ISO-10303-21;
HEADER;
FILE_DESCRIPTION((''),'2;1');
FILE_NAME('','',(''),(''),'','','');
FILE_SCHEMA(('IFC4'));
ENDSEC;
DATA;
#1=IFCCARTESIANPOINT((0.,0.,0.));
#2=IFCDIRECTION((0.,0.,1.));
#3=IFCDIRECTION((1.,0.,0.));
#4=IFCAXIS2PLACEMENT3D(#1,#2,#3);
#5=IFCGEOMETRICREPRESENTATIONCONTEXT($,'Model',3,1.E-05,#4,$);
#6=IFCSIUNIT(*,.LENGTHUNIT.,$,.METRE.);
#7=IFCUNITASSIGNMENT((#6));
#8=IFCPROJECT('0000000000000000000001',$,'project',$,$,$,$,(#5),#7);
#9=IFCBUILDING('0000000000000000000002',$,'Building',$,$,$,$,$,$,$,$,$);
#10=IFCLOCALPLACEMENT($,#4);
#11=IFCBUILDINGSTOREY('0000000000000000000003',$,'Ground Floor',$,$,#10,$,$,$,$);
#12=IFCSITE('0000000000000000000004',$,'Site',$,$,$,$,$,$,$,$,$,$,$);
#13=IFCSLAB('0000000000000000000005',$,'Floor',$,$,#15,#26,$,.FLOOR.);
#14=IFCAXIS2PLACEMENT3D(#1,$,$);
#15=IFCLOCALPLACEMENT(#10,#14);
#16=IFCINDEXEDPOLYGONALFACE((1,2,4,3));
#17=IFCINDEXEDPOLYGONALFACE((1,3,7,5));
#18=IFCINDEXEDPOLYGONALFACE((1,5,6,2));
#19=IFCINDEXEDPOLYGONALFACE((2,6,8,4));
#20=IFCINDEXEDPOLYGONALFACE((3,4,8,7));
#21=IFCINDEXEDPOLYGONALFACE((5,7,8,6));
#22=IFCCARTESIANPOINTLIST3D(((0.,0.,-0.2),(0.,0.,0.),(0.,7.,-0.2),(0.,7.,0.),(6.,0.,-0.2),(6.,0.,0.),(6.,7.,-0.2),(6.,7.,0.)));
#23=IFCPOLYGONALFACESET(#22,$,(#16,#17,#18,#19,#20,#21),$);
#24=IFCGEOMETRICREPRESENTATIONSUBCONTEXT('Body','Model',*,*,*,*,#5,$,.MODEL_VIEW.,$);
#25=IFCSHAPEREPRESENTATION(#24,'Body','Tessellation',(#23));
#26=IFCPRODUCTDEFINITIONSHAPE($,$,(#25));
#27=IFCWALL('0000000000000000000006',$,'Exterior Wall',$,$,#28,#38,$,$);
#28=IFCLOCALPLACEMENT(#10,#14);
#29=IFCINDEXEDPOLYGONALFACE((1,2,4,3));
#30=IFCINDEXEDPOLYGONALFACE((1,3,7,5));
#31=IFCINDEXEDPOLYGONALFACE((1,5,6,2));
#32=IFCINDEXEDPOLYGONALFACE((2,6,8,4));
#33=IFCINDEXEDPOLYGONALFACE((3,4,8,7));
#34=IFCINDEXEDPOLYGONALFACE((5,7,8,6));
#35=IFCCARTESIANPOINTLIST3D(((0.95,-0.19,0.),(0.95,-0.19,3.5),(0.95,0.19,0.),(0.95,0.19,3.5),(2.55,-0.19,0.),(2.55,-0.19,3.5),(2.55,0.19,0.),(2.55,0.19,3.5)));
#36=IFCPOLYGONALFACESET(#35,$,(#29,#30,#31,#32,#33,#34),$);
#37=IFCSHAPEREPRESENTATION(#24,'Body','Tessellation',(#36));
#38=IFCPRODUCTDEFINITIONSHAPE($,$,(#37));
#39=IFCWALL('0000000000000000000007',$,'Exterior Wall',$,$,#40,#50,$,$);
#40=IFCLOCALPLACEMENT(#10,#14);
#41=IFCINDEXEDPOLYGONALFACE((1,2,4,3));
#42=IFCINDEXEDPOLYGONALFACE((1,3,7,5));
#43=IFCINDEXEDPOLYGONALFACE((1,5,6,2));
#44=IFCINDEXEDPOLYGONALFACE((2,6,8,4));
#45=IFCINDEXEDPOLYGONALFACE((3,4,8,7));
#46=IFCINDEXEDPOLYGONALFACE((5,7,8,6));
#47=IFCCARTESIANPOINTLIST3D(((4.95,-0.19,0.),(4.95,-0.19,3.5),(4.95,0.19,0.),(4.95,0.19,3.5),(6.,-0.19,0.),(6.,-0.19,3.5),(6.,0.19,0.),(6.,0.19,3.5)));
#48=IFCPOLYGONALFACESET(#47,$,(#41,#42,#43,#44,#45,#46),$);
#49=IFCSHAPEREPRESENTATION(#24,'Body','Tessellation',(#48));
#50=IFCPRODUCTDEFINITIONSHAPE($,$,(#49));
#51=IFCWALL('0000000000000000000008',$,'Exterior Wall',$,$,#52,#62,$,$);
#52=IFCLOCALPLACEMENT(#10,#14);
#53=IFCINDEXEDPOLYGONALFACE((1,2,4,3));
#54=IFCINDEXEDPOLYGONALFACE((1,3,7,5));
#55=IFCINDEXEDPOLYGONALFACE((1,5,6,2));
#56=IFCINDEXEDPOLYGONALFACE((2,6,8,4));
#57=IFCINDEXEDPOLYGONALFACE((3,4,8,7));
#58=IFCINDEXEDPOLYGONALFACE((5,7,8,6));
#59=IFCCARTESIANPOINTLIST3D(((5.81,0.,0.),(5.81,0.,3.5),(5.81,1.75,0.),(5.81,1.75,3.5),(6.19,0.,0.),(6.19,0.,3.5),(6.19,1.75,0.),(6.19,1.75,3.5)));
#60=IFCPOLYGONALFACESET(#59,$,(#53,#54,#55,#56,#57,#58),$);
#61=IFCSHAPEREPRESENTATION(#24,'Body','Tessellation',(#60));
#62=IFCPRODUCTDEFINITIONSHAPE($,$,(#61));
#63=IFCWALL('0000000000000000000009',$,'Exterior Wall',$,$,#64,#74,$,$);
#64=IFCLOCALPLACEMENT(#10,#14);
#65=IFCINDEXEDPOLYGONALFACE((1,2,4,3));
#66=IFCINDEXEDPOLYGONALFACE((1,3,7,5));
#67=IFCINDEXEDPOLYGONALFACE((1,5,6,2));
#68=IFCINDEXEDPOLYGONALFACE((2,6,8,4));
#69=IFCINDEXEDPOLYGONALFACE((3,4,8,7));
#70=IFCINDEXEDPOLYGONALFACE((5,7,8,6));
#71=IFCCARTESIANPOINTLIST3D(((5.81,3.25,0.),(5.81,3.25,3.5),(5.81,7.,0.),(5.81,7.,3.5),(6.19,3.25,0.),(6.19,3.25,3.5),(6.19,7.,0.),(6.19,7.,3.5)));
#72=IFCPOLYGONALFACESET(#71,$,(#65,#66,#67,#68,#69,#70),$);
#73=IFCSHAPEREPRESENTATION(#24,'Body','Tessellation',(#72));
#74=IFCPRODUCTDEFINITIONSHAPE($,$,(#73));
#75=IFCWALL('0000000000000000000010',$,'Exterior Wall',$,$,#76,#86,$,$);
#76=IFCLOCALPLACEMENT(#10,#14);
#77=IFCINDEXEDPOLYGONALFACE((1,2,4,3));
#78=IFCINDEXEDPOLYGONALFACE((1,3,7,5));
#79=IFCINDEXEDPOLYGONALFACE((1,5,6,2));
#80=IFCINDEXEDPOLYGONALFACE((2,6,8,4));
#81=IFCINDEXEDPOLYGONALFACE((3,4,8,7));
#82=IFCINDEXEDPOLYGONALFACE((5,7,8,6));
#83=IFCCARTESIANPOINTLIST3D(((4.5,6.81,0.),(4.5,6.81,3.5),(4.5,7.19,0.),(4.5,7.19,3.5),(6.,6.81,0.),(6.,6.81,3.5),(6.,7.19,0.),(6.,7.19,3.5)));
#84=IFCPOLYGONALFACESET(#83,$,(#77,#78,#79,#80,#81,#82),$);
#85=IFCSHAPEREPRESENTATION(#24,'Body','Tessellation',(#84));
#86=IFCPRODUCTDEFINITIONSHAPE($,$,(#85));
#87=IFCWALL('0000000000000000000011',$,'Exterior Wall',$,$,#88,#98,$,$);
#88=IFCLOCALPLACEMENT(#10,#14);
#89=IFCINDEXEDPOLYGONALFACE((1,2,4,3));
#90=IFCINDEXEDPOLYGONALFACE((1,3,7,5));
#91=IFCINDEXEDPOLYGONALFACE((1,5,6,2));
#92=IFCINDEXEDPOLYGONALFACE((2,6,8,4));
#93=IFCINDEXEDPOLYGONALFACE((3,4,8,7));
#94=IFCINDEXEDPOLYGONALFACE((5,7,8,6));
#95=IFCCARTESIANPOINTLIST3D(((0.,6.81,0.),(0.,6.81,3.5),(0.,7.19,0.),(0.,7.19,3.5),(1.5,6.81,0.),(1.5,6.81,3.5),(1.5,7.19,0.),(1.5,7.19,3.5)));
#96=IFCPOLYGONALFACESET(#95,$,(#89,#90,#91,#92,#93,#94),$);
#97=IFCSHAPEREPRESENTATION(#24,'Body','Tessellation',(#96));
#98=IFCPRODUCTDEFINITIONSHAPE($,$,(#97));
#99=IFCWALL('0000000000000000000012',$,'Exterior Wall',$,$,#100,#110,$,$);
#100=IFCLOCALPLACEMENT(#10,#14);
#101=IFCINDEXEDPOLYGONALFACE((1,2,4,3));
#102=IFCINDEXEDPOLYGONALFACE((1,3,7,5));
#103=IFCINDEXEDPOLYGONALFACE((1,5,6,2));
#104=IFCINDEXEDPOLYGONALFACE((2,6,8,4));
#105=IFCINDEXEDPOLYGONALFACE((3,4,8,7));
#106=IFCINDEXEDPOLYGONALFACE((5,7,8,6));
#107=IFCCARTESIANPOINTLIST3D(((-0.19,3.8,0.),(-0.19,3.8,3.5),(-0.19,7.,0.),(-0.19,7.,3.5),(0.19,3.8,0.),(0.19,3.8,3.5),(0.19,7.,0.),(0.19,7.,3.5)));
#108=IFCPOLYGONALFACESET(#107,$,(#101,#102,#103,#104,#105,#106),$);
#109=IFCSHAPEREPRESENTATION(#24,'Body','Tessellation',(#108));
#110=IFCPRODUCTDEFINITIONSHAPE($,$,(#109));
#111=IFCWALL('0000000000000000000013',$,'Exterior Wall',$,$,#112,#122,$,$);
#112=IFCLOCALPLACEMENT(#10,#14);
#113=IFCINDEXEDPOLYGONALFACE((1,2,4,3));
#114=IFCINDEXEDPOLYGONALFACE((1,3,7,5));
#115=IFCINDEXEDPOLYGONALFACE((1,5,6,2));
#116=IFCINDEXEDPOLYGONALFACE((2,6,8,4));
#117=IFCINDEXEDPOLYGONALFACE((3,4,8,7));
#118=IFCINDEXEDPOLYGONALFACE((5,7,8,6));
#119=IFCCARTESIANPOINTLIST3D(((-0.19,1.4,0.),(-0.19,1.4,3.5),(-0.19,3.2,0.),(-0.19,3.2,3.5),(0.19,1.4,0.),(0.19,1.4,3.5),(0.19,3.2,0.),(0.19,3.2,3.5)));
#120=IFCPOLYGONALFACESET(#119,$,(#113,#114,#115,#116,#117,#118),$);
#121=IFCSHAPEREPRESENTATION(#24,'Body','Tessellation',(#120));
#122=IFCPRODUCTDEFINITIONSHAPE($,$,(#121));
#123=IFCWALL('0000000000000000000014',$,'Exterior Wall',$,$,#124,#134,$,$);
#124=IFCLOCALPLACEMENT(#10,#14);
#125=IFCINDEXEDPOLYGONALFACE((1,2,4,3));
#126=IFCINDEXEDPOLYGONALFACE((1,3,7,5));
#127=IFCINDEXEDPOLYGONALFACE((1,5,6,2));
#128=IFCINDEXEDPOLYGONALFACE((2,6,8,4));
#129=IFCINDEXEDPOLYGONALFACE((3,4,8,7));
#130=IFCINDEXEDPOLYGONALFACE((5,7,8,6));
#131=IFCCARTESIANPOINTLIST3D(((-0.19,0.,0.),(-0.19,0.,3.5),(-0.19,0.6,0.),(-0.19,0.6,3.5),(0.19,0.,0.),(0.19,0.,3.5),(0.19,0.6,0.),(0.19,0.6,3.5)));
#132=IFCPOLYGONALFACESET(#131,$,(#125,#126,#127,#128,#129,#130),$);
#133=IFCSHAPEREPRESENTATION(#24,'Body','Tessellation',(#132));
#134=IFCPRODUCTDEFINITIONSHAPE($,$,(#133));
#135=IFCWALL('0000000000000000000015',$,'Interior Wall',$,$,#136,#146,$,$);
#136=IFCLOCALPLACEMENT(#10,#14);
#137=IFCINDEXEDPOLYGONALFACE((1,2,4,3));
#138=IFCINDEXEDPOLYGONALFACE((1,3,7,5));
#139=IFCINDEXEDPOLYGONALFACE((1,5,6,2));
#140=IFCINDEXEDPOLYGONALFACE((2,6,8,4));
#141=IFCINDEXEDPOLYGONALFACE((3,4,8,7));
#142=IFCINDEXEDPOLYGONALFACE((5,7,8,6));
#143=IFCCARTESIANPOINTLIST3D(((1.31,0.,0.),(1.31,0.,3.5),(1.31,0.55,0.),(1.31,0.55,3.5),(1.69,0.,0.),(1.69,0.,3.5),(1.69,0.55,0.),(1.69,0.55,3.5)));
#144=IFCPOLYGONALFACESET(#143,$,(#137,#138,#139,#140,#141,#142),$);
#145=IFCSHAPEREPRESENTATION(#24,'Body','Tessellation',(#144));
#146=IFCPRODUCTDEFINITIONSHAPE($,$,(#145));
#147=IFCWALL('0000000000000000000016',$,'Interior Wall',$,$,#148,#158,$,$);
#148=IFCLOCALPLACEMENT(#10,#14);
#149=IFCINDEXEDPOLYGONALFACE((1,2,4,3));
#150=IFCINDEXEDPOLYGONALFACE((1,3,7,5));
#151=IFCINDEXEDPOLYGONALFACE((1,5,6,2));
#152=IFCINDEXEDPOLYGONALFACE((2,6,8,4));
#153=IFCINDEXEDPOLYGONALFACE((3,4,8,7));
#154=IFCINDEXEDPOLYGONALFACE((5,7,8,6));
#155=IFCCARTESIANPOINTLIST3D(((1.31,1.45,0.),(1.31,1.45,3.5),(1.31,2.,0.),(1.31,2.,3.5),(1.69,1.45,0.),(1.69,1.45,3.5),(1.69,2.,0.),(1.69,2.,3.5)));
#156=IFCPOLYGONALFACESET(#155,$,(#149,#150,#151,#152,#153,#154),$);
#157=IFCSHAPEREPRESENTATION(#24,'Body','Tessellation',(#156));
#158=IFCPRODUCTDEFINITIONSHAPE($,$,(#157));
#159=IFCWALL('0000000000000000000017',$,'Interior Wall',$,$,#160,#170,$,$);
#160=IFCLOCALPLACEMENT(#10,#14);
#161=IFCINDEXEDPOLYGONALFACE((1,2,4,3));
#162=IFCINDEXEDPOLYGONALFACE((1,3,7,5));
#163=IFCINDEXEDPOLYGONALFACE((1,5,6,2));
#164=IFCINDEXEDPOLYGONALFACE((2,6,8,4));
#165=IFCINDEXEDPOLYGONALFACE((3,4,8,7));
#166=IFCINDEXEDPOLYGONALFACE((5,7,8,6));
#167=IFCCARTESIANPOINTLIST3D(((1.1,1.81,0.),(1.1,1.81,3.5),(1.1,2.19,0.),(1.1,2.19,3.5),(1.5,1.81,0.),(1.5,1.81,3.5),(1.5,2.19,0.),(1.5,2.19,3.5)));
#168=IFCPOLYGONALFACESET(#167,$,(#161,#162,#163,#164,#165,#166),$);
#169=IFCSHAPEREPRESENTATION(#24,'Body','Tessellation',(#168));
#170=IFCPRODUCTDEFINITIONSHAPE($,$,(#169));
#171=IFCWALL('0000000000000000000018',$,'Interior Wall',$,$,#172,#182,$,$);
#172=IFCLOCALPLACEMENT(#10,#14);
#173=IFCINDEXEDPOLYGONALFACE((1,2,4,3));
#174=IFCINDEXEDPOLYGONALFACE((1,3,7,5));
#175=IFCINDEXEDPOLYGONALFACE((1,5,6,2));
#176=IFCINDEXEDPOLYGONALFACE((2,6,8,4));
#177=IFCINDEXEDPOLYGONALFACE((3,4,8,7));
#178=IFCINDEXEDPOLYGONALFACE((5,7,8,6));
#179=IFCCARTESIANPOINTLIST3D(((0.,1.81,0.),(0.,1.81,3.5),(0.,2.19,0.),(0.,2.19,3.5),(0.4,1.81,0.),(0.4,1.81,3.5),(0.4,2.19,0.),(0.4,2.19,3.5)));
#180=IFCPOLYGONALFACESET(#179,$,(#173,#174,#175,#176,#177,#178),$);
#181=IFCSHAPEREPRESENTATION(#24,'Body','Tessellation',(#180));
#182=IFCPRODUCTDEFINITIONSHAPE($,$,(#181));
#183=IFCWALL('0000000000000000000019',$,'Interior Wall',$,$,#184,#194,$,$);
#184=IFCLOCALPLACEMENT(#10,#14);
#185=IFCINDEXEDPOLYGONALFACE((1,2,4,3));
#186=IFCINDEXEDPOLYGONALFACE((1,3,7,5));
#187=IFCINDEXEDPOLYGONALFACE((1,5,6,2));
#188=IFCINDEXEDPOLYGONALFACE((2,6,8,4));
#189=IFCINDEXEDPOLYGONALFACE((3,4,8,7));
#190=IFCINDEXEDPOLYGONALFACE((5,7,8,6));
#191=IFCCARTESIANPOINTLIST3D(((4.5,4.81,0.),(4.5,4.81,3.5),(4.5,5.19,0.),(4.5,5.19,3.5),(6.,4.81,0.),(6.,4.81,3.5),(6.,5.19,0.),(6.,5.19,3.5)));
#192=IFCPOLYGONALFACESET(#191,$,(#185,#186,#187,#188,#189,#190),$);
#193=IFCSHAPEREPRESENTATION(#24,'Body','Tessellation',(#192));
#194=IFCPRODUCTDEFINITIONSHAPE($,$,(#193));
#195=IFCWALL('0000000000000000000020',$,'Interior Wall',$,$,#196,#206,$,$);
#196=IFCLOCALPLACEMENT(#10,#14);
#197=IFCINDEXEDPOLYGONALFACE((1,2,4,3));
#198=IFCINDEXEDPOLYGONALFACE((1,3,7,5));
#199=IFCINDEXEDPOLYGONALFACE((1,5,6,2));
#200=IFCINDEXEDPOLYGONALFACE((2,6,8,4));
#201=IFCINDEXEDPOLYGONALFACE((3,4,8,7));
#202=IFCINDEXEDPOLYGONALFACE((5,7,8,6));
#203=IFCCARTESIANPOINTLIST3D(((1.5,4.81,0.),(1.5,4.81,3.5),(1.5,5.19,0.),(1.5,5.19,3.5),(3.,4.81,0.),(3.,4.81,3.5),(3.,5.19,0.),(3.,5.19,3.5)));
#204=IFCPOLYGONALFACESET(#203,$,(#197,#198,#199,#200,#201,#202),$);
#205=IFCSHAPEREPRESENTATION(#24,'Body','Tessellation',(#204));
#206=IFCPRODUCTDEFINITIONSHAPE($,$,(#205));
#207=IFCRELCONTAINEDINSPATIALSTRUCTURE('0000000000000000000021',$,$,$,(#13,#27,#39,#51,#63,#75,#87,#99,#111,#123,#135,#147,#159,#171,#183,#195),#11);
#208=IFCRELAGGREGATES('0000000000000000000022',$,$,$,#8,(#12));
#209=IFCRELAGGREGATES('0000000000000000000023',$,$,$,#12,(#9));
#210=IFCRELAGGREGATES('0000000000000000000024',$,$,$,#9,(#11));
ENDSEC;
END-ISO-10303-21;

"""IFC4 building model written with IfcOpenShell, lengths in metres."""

from ifc_helpers import new_model, si_unit, frame, origin_with_axes, place, context, subcontext, project, spatial, indexed_curve, outline, extrude, element, save


model = new_model("IFC4")

# Units and contexts
model_context = context("Model", 3, precision=1e-05, world=origin_with_axes())
body_context = subcontext(model_context, "Body", "Model", "MODEL_VIEW")
ifc_project = project(units=[si_unit("LENGTHUNIT", "METRE")], contexts=[model_context])

# Site, building, storey
site = spatial("IfcSite", under=ifc_project, Name="Site")
building = spatial("IfcBuilding", under=site, Name="Building")
storey_placement = place(None, origin_with_axes())
storey = spatial("IfcBuildingStorey", under=building, at=storey_placement, Name="Ground Floor")

# Slab
slab_placement = place(storey_placement, frame((0.0, 0.0, -0.2), z_axis=(0.0, 0.0, 1.0), x_axis=(1.0, 0.0, 0.0)))
element("IfcSlab", 1, at=slab_placement, inside=storey, Name="Floor", PredefinedType="FLOOR", context=body_context, shape_type="SweptSolid", body=[
    extrude(outline(indexed_curve([(0.0, 0.0), (6.0, 0.0), (6.0, 7.0), (0.0, 7.0)])), None, (0.0, 0.0, 1.0), 0.2),
])

# Walls
wall_1_placement = place(storey_placement, frame((0.95, 0.0, 0.0), z_axis=(0.0, 0.0, 1.0), x_axis=(1.0, 0.0, 0.0)))
element("IfcWall", 2, at=wall_1_placement, inside=storey, Name="Exterior Wall", context=body_context, shape_type="SweptSolid", body=[
    extrude(outline(indexed_curve([(0.0, 0.0), (0.0, 0.38), (1.6, 0.38), (1.6, 0.0), (0.0, 0.0)], self_intersect=False)), frame((0.0, -0.19, 0.0), z_axis=(0.0, 0.0, 1.0), x_axis=(1.0, 0.0, 0.0)), (0.0, 0.0, 1.0), 3.5),
])
wall_2_placement = place(storey_placement, frame((4.95, 0.0, 0.0), z_axis=(0.0, 0.0, 1.0), x_axis=(1.0, 0.0, 0.0)))
element("IfcWall", 3, at=wall_2_placement, inside=storey, Name="Exterior Wall", context=body_context, shape_type="SweptSolid", body=[
    extrude(outline(indexed_curve([(0.0, 0.0), (0.0, 0.38), (1.05, 0.38), (1.05, 0.0), (0.0, 0.0)], self_intersect=False)), frame((0.0, -0.19, 0.0), z_axis=(0.0, 0.0, 1.0), x_axis=(1.0, 0.0, 0.0)), (0.0, 0.0, 1.0), 3.5),
])
wall_3_placement = place(storey_placement, frame((6.0, 0.0, 0.0), z_axis=(0.0, 0.0, 1.0), x_axis=(0.0, 1.0, 0.0)))
element("IfcWall", 4, at=wall_3_placement, inside=storey, Name="Exterior Wall", context=body_context, shape_type="SweptSolid", body=[
    extrude(outline(indexed_curve([(0.0, 0.0), (0.0, 0.38), (1.75, 0.38), (1.75, 0.0), (0.0, 0.0)], self_intersect=False)), frame((0.0, -0.19, 0.0), z_axis=(0.0, 0.0, 1.0), x_axis=(1.0, 0.0, 0.0)), (0.0, 0.0, 1.0), 3.5),
])
wall_4_placement = place(storey_placement, frame((6.0, 3.25, 0.0), z_axis=(0.0, 0.0, 1.0), x_axis=(0.0, 1.0, 0.0)))
element("IfcWall", 5, at=wall_4_placement, inside=storey, Name="Exterior Wall", context=body_context, shape_type="SweptSolid", body=[
    extrude(outline(indexed_curve([(0.0, 0.0), (0.0, 0.38), (3.75, 0.38), (3.75, 0.0), (0.0, 0.0)], self_intersect=False)), frame((0.0, -0.19, 0.0), z_axis=(0.0, 0.0, 1.0), x_axis=(1.0, 0.0, 0.0)), (0.0, 0.0, 1.0), 3.5),
])
for number, where, z_axis, x_axis, name in (
    (6, (6.0, 7.0, 0.0), (0.0, 0.0, 1.0), (-1.0, 0.0, 0.0), "Exterior Wall"),
    (7, (1.5, 7.0, 0.0), (0.0, 0.0, 1.0), (-1.0, 0.0, 0.0), "Exterior Wall"),
):
    element("IfcWall", number, at=place(storey_placement, frame(where, z_axis=z_axis, x_axis=x_axis)), inside=storey, Name=name, context=body_context, shape_type="SweptSolid", body=[
        extrude(outline(indexed_curve([(0.0, 0.0), (0.0, 0.38), (1.5, 0.38), (1.5, 0.0), (0.0, 0.0)], self_intersect=False)), frame((0.0, -0.19, 0.0), z_axis=(0.0, 0.0, 1.0), x_axis=(1.0, 0.0, 0.0)), (0.0, 0.0, 1.0), 3.5),
    ])
wall_5_placement = place(storey_placement, frame((0.0, 7.0, 0.0), z_axis=(0.0, 0.0, 1.0), x_axis=(0.0, -1.0, 0.0)))
element("IfcWall", 8, at=wall_5_placement, inside=storey, Name="Exterior Wall", context=body_context, shape_type="SweptSolid", body=[
    extrude(outline(indexed_curve([(0.0, 0.0), (0.0, 0.38), (3.2, 0.38), (3.2, 0.0), (0.0, 0.0)], self_intersect=False)), frame((0.0, -0.19, 0.0), z_axis=(0.0, 0.0, 1.0), x_axis=(1.0, 0.0, 0.0)), (0.0, 0.0, 1.0), 3.5),
])
wall_6_placement = place(storey_placement, frame((0.0, 3.2, 0.0), z_axis=(0.0, 0.0, 1.0), x_axis=(0.0, -1.0, 0.0)))
element("IfcWall", 9, at=wall_6_placement, inside=storey, Name="Exterior Wall", context=body_context, shape_type="SweptSolid", body=[
    extrude(outline(indexed_curve([(0.0, 0.0), (0.0, 0.38), (1.8, 0.38), (1.8, 0.0), (0.0, 0.0)], self_intersect=False)), frame((0.0, -0.19, 0.0), z_axis=(0.0, 0.0, 1.0), x_axis=(1.0, 0.0, 0.0)), (0.0, 0.0, 1.0), 3.5),
])
wall_7_placement = place(storey_placement, frame((0.0, 0.6, 0.0), z_axis=(0.0, 0.0, 1.0), x_axis=(0.0, -1.0, 0.0)))
element("IfcWall", 10, at=wall_7_placement, inside=storey, Name="Exterior Wall", context=body_context, shape_type="SweptSolid", body=[
    extrude(outline(indexed_curve([(0.0, 0.0), (0.0, 0.38), (0.6, 0.38), (0.6, 0.0), (0.0, 0.0)], self_intersect=False)), frame((0.0, -0.19, 0.0), z_axis=(0.0, 0.0, 1.0), x_axis=(1.0, 0.0, 0.0)), (0.0, 0.0, 1.0), 3.5),
])
for number, where, z_axis, x_axis, name in (
    (11, (1.5, 0.0, 0.0), (0.0, 0.0, 1.0), (0.0, 1.0, 0.0), "Interior Wall"),
    (12, (1.5, 1.45, 0.0), (0.0, 0.0, 1.0), (0.0, 1.0, 0.0), "Interior Wall"),
):
    element("IfcWall", number, at=place(storey_placement, frame(where, z_axis=z_axis, x_axis=x_axis)), inside=storey, Name=name, context=body_context, shape_type="SweptSolid", body=[
        extrude(outline(indexed_curve([(0.0, 0.0), (0.0, 0.38), (0.55, 0.38), (0.55, 0.0), (0.0, 0.0)], self_intersect=False)), frame((0.0, -0.19, 0.0), z_axis=(0.0, 0.0, 1.0), x_axis=(1.0, 0.0, 0.0)), (0.0, 0.0, 1.0), 3.5),
    ])
for number, where, z_axis, x_axis, name in (
    (13, (1.5, 2.0, 0.0), (0.0, 0.0, 1.0), (-1.0, 0.0, 0.0), "Interior Wall"),
    (14, (0.4, 2.0, 0.0), (0.0, 0.0, 1.0), (-1.0, 0.0, 0.0), "Interior Wall"),
):
    element("IfcWall", number, at=place(storey_placement, frame(where, z_axis=z_axis, x_axis=x_axis)), inside=storey, Name=name, context=body_context, shape_type="SweptSolid", body=[
        extrude(outline(indexed_curve([(0.0, 0.0), (0.0, 0.38), (0.4, 0.38), (0.4, 0.0), (0.0, 0.0)], self_intersect=False)), frame((0.0, -0.19, 0.0), z_axis=(0.0, 0.0, 1.0), x_axis=(1.0, 0.0, 0.0)), (0.0, 0.0, 1.0), 3.5),
    ])
for number, where, z_axis, x_axis, name in (
    (15, (6.0, 5.0, 0.0), (0.0, 0.0, 1.0), (-1.0, 0.0, 0.0), "Interior Wall"),
    (16, (3.0, 5.0, 0.0), (0.0, 0.0, 1.0), (-1.0, 0.0, 0.0), "Interior Wall"),
):
    element("IfcWall", number, at=place(storey_placement, frame(where, z_axis=z_axis, x_axis=x_axis)), inside=storey, Name=name, context=body_context, shape_type="SweptSolid", body=[
        extrude(outline(indexed_curve([(0.0, 0.0), (0.0, 0.38), (1.5, 0.38), (1.5, 0.0), (0.0, 0.0)], self_intersect=False)), frame((0.0, -0.19, 0.0), z_axis=(0.0, 0.0, 1.0), x_axis=(1.0, 0.0, 0.0)), (0.0, 0.0, 1.0), 3.5),
    ])

save(model, "model.ifc")
